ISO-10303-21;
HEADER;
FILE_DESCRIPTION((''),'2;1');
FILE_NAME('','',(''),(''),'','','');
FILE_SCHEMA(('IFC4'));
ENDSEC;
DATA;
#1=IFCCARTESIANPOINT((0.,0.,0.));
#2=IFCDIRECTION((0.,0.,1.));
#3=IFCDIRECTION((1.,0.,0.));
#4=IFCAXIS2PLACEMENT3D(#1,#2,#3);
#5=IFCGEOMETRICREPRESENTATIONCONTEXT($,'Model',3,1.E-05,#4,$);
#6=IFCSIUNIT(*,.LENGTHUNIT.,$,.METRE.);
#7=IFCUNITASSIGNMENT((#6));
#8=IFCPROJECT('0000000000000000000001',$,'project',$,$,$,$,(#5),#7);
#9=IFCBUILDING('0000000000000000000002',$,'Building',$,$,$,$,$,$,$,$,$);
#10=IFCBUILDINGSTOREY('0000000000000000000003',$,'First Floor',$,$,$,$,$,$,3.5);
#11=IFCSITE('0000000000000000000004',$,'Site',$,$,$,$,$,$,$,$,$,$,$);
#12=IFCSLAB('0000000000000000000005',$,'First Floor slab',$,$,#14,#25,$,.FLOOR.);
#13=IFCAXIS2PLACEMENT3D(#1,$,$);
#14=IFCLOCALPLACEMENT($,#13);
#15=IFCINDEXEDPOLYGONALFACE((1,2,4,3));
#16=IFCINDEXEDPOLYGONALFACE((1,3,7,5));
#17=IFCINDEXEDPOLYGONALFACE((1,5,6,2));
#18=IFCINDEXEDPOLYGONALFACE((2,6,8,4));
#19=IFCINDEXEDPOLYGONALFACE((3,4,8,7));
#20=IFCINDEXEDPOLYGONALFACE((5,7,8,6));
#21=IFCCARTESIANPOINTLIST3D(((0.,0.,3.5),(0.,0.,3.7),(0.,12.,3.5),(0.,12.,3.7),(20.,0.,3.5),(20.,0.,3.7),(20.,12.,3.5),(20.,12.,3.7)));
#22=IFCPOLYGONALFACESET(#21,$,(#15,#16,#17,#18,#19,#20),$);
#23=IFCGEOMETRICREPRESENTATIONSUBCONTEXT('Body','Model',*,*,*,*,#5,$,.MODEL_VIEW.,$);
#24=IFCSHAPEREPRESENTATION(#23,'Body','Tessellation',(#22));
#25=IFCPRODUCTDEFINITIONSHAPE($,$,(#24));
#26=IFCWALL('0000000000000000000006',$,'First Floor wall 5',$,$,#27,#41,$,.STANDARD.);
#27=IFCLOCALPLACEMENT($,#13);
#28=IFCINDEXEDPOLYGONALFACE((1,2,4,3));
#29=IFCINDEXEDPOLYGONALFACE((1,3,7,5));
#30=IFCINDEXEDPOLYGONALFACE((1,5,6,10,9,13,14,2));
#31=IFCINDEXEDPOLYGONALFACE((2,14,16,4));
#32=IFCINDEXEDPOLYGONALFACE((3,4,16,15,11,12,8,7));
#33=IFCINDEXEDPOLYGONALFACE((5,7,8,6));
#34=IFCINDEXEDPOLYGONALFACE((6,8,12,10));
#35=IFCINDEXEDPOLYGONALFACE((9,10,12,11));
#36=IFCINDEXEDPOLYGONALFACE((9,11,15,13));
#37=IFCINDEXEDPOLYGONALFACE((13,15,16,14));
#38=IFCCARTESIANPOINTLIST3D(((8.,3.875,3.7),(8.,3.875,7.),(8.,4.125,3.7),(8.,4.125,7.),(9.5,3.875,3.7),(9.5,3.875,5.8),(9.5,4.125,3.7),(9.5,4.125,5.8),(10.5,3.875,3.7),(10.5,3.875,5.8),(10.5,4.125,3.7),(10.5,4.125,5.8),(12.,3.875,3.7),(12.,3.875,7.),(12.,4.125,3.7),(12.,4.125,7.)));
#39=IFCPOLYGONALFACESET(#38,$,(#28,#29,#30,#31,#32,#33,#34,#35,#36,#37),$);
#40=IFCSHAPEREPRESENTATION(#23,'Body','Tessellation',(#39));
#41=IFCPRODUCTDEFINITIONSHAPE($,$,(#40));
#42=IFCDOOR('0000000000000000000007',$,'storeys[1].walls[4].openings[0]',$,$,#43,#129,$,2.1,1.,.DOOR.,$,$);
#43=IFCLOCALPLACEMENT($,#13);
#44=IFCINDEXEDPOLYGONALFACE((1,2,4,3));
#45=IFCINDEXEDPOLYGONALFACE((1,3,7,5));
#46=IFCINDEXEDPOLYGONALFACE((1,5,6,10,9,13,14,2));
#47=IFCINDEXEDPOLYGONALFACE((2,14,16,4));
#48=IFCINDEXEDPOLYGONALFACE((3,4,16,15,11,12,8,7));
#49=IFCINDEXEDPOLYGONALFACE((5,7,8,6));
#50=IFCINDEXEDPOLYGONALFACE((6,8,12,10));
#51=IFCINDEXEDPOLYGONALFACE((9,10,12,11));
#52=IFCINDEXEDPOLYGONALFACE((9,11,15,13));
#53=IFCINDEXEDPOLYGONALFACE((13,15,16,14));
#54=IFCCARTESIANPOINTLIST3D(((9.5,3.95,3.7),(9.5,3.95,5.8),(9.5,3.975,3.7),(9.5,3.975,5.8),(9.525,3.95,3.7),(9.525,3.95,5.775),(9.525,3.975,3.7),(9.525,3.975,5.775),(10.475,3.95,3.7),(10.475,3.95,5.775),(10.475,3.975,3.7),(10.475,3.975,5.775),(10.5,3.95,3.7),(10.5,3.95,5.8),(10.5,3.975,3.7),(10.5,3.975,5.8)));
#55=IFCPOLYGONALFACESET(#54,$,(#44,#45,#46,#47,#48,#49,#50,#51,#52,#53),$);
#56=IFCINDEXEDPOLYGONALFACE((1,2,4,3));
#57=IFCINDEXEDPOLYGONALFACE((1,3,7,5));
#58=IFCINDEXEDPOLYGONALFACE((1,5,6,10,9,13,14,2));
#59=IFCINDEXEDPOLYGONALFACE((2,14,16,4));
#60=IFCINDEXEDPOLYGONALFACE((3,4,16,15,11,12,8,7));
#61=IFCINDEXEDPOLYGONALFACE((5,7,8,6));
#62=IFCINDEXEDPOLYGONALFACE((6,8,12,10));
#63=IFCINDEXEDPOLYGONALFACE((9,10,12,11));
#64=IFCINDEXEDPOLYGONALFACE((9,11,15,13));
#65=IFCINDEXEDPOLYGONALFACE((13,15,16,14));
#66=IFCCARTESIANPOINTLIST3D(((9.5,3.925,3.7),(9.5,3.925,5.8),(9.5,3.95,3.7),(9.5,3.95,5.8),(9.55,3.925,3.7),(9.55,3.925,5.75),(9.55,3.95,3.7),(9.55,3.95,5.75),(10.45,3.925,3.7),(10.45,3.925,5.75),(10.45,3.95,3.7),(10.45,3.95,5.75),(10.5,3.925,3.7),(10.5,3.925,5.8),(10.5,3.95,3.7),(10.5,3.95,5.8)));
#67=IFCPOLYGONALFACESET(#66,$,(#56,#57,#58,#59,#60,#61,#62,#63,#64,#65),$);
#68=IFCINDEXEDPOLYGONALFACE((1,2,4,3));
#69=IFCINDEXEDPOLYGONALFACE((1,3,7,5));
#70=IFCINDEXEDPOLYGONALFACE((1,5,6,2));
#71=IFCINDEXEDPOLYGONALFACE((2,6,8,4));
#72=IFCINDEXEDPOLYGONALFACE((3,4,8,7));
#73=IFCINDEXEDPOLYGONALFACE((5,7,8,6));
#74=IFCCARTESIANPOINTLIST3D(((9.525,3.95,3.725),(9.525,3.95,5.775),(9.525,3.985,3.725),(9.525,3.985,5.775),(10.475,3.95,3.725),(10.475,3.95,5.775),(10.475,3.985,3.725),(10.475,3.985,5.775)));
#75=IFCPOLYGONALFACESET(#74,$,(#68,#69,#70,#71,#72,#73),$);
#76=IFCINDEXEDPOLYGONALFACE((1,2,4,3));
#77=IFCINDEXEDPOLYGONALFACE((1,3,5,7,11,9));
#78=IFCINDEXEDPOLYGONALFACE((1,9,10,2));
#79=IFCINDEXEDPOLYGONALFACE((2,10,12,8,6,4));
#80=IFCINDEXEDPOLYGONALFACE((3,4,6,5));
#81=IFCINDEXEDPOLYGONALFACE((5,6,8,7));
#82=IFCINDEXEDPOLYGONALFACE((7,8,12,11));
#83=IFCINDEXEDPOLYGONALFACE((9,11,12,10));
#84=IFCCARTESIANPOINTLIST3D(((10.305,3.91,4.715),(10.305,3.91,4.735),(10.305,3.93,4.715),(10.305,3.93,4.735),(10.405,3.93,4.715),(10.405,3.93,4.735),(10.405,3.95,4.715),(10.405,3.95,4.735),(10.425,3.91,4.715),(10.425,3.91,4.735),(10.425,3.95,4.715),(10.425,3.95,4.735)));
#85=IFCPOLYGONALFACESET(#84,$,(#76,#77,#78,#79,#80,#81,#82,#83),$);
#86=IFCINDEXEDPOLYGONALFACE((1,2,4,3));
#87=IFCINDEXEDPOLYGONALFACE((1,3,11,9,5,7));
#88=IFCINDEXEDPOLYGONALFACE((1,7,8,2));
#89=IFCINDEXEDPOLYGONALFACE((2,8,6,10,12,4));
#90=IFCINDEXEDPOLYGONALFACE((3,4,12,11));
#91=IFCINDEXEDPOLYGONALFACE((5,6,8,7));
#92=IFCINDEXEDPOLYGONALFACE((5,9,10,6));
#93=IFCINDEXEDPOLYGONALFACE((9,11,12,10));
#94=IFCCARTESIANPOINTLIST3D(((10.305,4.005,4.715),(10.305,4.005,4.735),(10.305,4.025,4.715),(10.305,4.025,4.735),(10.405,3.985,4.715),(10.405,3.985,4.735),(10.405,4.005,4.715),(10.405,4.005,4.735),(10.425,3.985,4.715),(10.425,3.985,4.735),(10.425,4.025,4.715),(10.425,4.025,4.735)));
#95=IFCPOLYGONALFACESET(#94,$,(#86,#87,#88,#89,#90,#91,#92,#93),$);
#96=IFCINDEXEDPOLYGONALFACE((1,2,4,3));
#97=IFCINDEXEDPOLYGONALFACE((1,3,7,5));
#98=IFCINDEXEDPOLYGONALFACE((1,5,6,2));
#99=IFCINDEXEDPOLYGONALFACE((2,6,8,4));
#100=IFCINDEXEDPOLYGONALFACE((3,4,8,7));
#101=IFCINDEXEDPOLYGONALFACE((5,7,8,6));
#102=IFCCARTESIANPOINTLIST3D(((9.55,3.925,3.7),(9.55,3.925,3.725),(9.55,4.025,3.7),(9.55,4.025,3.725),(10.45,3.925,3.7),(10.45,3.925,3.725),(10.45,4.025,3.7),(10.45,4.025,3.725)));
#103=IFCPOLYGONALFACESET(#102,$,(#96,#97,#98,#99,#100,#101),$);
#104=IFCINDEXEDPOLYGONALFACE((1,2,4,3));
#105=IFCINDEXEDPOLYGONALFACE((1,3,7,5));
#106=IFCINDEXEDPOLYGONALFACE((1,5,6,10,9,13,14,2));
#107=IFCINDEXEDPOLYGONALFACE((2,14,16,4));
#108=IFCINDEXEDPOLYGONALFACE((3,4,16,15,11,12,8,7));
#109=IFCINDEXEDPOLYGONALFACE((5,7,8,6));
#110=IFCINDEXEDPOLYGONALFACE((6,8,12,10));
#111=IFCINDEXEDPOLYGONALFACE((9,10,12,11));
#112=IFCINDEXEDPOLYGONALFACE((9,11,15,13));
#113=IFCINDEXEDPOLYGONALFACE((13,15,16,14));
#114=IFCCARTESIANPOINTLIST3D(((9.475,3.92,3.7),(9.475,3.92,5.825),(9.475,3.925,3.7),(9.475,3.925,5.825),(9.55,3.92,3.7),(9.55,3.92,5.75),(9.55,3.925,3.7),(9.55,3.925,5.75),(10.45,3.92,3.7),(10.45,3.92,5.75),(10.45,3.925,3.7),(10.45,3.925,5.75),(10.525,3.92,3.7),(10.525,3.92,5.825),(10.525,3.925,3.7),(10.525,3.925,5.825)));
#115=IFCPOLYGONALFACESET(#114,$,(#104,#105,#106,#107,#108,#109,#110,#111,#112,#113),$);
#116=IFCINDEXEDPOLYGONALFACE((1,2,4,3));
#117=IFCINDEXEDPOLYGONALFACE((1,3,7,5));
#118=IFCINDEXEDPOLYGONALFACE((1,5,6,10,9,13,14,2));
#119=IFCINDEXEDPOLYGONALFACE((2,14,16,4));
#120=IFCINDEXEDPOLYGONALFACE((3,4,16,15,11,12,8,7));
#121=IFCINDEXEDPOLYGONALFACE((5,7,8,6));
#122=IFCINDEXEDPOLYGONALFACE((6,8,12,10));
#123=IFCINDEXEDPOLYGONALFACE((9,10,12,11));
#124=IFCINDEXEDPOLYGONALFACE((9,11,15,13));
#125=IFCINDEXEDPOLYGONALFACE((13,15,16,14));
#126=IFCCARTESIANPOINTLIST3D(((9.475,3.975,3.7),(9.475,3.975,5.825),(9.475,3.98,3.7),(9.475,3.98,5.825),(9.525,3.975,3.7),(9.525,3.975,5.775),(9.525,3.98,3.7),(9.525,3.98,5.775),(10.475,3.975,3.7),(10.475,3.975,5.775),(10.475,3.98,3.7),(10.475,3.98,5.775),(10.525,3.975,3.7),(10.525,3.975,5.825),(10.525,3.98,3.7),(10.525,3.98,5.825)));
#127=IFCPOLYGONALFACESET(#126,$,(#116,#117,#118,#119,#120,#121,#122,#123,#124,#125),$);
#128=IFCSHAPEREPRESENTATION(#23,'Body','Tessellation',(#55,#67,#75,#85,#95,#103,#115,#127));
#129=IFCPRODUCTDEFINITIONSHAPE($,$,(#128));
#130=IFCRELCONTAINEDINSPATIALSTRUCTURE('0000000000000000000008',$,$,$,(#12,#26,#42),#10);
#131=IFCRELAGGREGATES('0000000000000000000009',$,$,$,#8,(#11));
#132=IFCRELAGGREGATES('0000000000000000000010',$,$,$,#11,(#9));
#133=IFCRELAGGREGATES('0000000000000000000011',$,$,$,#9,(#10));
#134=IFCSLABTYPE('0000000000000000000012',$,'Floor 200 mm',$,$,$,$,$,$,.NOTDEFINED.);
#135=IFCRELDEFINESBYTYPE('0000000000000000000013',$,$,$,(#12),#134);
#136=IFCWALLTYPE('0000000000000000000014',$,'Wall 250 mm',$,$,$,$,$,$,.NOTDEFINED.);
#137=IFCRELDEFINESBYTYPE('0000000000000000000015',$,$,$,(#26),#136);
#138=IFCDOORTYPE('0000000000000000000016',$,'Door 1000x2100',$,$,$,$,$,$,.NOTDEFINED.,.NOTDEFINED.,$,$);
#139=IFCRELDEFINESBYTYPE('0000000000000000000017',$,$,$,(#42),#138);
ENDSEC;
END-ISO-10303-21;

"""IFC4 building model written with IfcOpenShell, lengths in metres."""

from ifc_helpers import new_model, si_unit, frame, origin_with_axes, place, context, subcontext, project, spatial, line, indexed_curve, outline, extrude, type_object, element, fill, save


model = new_model("IFC4")

# Units and contexts
model_context = context("Model", 3, precision=1e-05, world=origin_with_axes())
body_context = subcontext(model_context, "Body", "Model", "MODEL_VIEW")
ifc_project = project(units=[si_unit("LENGTHUNIT", "METRE")], contexts=[model_context])

# Site, building, storey
site = spatial("IfcSite", under=ifc_project, Name="Site")
building = spatial("IfcBuilding", under=site, Name="Building")
storey = spatial("IfcBuildingStorey", under=building, Name="First Floor", Elevation=3.5)

# Slab
slab_type = type_object("IfcSlabType", Name="Floor 200 mm", PredefinedType="NOTDEFINED")
slab_placement = place(None, frame((0.0, 0.0, 3.5), z_axis=(0.0, 0.0, 1.0), x_axis=(1.0, 0.0, 0.0)))
element("IfcSlab", 1, at=slab_placement, inside=storey, type_object=slab_type, Name="First Floor slab", PredefinedType="FLOOR", context=body_context, shape_type="SweptSolid", body=[
    extrude(outline(indexed_curve([(0.0, 0.0), (20.0, 0.0), (20.0, 12.0), (0.0, 12.0)])), None, (0.0, 0.0, 1.0), 0.2),
])

# Wall, opening, door
wall_type_1 = type_object("IfcWallType", Name="Wall 250 mm", PredefinedType="NOTDEFINED")
wall_1_placement = place(None, frame((8.0, 4.0, 3.7), z_axis=(0.0, 0.0, 1.0), x_axis=(1.0, 0.0, 0.0)))
wall_1 = element("IfcWall", 2, at=wall_1_placement, inside=storey, type_object=wall_type_1, Name="First Floor wall 5", PredefinedType="STANDARD", context=body_context, shape_type="SweptSolid", body=[
    extrude(outline(indexed_curve([(0.0, 0.0), (0.0, 0.25), (4.0, 0.25), (4.0, 0.0), (0.0, 0.0)], self_intersect=False)), frame((0.0, -0.125, 0.0), z_axis=(0.0, 0.0, 1.0), x_axis=(1.0, 0.0, 0.0)), (0.0, 0.0, 1.0), 3.3),
])
opening_1_placement = place(wall_1_placement, frame((1.5, -0.135, 0.0), z_axis=(0.0, 0.0, 1.0), x_axis=(1.0, 0.0, 0.0)))
opening_1 = element("IfcOpeningElement", 3, at=opening_1_placement, cuts=wall_1, context=body_context, shape_type="SweptSolid", body=[
    extrude(outline(indexed_curve([(0.0, 0.0), (0.0, 0.27), (1.0, 0.27), (1.0, 0.0), (0.0, 0.0)], self_intersect=False)), origin_with_axes(), (0.0, 0.0, 1.0), 2.1),
])
door_type = type_object("IfcDoorType", Name="Door 1000x2100", OperationType="NOTDEFINED", PredefinedType="NOTDEFINED")
door_placement = place(None, frame((9.5, 3.925, 3.7), z_axis=(0.0, 0.0, 1.0), x_axis=(1.0, 0.0, 0.0)))
door = element("IfcDoor", 4, at=door_placement, inside=storey, type_object=door_type, Name="storeys[1].walls[4].openings[0]", OverallHeight=2.1, OverallWidth=1.0, PredefinedType="DOOR", context=body_context, shape_type="SweptSolid", body=[
    extrude(outline(indexed_curve([(0.0, 0.0), (0.0, 2.1), (1.0, 2.1), (1.0, 0.0), (0.975, 0.0), (0.975, 2.075), (0.025, 2.075), (0.025, 0.0)], segments=[line(1, 2, 3, 4, 5, 6, 7, 8, 1)])), frame((0.0, 0.025, 0.0), z_axis=(0.0, -1.0, 0.0), x_axis=(1.0, 0.0, 0.0)), (0.0, 0.0, -1.0), 0.025),
    extrude(outline(indexed_curve([(0.0, 0.0), (0.0, 2.1), (1.0, 2.1), (1.0, 0.0), (0.95, 0.0), (0.95, 2.05), (0.05, 2.05), (0.05, 0.0)], segments=[line(1, 2, 3, 4, 5, 6, 7, 8, 1)])), frame((0.0, 0.0, 0.0), z_axis=(0.0, -1.0, 0.0), x_axis=(1.0, 0.0, 0.0)), (0.0, 0.0, -1.0), 0.025),
    extrude(outline(indexed_curve([(0.0, 0.0), (0.95, 0.0), (0.95, 0.035), (0.0, 0.035)], segments=[line(1, 2, 3, 4, 1)])), frame((0.025, 0.025, 0.025), z_axis=(0.0, 0.0, 1.0), x_axis=(1.0, 0.0, 0.0)), (0.0, 0.0, 1.0), 2.05),
    extrude(outline(indexed_curve([(0.0, 0.0), (0.0, -0.04), (-0.12, -0.04), (-0.12, -0.02), (-0.02, -0.02), (-0.02, 0.0)], segments=[line(1, 2, 3, 4, 5, 6, 1)])), frame((0.925, 0.025, 1.015), z_axis=(0.0, 0.0, 1.0), x_axis=(1.0, 0.0, 0.0)), (0.0, 0.0, 1.0), 0.02),
    extrude(outline(indexed_curve([(0.0, 0.0), (0.0, 0.04), (-0.12, 0.04), (-0.12, 0.02), (-0.02, 0.02), (-0.02, 0.0)], segments=[line(1, 2, 3, 4, 5, 6, 1)])), frame((0.925, 0.06, 1.015), z_axis=(0.0, 0.0, 1.0), x_axis=(1.0, 0.0, 0.0)), (0.0, 0.0, 1.0), 0.02),
    extrude(outline(indexed_curve([(0.0, 0.0), (0.9, 0.0), (0.9, 0.1), (0.0, 0.1)], segments=[line(1, 2, 3, 4, 1)])), frame((0.05, 0.0, 0.0), z_axis=(0.0, 0.0, 1.0), x_axis=(1.0, 0.0, 0.0)), (0.0, 0.0, 1.0), 0.025),
    extrude(outline(indexed_curve([(0.0, 0.0), (0.0, 2.125), (1.05, 2.125), (1.05, 0.0), (0.975, 0.0), (0.975, 2.05), (0.075, 2.05), (0.075, 0.0)], segments=[line(1, 2, 3, 4, 5, 6, 7, 8, 1)])), frame((-0.025, -0.005, 0.0), z_axis=(0.0, -1.0, 0.0), x_axis=(1.0, 0.0, 0.0)), (0.0, 0.0, -1.0), 0.005),
    extrude(outline(indexed_curve([(0.0, 0.0), (0.0, 2.125), (1.05, 2.125), (1.05, 0.0), (1.0, 0.0), (1.0, 2.075), (0.05, 2.075), (0.05, 0.0)], segments=[line(1, 2, 3, 4, 5, 6, 7, 8, 1)])), frame((-0.025, 0.05, 0.0), z_axis=(0.0, -1.0, 0.0), x_axis=(1.0, 0.0, 0.0)), (0.0, 0.0, -1.0), 0.005),
])
fill(opening_1, door)

save(model, "model.ifc")
